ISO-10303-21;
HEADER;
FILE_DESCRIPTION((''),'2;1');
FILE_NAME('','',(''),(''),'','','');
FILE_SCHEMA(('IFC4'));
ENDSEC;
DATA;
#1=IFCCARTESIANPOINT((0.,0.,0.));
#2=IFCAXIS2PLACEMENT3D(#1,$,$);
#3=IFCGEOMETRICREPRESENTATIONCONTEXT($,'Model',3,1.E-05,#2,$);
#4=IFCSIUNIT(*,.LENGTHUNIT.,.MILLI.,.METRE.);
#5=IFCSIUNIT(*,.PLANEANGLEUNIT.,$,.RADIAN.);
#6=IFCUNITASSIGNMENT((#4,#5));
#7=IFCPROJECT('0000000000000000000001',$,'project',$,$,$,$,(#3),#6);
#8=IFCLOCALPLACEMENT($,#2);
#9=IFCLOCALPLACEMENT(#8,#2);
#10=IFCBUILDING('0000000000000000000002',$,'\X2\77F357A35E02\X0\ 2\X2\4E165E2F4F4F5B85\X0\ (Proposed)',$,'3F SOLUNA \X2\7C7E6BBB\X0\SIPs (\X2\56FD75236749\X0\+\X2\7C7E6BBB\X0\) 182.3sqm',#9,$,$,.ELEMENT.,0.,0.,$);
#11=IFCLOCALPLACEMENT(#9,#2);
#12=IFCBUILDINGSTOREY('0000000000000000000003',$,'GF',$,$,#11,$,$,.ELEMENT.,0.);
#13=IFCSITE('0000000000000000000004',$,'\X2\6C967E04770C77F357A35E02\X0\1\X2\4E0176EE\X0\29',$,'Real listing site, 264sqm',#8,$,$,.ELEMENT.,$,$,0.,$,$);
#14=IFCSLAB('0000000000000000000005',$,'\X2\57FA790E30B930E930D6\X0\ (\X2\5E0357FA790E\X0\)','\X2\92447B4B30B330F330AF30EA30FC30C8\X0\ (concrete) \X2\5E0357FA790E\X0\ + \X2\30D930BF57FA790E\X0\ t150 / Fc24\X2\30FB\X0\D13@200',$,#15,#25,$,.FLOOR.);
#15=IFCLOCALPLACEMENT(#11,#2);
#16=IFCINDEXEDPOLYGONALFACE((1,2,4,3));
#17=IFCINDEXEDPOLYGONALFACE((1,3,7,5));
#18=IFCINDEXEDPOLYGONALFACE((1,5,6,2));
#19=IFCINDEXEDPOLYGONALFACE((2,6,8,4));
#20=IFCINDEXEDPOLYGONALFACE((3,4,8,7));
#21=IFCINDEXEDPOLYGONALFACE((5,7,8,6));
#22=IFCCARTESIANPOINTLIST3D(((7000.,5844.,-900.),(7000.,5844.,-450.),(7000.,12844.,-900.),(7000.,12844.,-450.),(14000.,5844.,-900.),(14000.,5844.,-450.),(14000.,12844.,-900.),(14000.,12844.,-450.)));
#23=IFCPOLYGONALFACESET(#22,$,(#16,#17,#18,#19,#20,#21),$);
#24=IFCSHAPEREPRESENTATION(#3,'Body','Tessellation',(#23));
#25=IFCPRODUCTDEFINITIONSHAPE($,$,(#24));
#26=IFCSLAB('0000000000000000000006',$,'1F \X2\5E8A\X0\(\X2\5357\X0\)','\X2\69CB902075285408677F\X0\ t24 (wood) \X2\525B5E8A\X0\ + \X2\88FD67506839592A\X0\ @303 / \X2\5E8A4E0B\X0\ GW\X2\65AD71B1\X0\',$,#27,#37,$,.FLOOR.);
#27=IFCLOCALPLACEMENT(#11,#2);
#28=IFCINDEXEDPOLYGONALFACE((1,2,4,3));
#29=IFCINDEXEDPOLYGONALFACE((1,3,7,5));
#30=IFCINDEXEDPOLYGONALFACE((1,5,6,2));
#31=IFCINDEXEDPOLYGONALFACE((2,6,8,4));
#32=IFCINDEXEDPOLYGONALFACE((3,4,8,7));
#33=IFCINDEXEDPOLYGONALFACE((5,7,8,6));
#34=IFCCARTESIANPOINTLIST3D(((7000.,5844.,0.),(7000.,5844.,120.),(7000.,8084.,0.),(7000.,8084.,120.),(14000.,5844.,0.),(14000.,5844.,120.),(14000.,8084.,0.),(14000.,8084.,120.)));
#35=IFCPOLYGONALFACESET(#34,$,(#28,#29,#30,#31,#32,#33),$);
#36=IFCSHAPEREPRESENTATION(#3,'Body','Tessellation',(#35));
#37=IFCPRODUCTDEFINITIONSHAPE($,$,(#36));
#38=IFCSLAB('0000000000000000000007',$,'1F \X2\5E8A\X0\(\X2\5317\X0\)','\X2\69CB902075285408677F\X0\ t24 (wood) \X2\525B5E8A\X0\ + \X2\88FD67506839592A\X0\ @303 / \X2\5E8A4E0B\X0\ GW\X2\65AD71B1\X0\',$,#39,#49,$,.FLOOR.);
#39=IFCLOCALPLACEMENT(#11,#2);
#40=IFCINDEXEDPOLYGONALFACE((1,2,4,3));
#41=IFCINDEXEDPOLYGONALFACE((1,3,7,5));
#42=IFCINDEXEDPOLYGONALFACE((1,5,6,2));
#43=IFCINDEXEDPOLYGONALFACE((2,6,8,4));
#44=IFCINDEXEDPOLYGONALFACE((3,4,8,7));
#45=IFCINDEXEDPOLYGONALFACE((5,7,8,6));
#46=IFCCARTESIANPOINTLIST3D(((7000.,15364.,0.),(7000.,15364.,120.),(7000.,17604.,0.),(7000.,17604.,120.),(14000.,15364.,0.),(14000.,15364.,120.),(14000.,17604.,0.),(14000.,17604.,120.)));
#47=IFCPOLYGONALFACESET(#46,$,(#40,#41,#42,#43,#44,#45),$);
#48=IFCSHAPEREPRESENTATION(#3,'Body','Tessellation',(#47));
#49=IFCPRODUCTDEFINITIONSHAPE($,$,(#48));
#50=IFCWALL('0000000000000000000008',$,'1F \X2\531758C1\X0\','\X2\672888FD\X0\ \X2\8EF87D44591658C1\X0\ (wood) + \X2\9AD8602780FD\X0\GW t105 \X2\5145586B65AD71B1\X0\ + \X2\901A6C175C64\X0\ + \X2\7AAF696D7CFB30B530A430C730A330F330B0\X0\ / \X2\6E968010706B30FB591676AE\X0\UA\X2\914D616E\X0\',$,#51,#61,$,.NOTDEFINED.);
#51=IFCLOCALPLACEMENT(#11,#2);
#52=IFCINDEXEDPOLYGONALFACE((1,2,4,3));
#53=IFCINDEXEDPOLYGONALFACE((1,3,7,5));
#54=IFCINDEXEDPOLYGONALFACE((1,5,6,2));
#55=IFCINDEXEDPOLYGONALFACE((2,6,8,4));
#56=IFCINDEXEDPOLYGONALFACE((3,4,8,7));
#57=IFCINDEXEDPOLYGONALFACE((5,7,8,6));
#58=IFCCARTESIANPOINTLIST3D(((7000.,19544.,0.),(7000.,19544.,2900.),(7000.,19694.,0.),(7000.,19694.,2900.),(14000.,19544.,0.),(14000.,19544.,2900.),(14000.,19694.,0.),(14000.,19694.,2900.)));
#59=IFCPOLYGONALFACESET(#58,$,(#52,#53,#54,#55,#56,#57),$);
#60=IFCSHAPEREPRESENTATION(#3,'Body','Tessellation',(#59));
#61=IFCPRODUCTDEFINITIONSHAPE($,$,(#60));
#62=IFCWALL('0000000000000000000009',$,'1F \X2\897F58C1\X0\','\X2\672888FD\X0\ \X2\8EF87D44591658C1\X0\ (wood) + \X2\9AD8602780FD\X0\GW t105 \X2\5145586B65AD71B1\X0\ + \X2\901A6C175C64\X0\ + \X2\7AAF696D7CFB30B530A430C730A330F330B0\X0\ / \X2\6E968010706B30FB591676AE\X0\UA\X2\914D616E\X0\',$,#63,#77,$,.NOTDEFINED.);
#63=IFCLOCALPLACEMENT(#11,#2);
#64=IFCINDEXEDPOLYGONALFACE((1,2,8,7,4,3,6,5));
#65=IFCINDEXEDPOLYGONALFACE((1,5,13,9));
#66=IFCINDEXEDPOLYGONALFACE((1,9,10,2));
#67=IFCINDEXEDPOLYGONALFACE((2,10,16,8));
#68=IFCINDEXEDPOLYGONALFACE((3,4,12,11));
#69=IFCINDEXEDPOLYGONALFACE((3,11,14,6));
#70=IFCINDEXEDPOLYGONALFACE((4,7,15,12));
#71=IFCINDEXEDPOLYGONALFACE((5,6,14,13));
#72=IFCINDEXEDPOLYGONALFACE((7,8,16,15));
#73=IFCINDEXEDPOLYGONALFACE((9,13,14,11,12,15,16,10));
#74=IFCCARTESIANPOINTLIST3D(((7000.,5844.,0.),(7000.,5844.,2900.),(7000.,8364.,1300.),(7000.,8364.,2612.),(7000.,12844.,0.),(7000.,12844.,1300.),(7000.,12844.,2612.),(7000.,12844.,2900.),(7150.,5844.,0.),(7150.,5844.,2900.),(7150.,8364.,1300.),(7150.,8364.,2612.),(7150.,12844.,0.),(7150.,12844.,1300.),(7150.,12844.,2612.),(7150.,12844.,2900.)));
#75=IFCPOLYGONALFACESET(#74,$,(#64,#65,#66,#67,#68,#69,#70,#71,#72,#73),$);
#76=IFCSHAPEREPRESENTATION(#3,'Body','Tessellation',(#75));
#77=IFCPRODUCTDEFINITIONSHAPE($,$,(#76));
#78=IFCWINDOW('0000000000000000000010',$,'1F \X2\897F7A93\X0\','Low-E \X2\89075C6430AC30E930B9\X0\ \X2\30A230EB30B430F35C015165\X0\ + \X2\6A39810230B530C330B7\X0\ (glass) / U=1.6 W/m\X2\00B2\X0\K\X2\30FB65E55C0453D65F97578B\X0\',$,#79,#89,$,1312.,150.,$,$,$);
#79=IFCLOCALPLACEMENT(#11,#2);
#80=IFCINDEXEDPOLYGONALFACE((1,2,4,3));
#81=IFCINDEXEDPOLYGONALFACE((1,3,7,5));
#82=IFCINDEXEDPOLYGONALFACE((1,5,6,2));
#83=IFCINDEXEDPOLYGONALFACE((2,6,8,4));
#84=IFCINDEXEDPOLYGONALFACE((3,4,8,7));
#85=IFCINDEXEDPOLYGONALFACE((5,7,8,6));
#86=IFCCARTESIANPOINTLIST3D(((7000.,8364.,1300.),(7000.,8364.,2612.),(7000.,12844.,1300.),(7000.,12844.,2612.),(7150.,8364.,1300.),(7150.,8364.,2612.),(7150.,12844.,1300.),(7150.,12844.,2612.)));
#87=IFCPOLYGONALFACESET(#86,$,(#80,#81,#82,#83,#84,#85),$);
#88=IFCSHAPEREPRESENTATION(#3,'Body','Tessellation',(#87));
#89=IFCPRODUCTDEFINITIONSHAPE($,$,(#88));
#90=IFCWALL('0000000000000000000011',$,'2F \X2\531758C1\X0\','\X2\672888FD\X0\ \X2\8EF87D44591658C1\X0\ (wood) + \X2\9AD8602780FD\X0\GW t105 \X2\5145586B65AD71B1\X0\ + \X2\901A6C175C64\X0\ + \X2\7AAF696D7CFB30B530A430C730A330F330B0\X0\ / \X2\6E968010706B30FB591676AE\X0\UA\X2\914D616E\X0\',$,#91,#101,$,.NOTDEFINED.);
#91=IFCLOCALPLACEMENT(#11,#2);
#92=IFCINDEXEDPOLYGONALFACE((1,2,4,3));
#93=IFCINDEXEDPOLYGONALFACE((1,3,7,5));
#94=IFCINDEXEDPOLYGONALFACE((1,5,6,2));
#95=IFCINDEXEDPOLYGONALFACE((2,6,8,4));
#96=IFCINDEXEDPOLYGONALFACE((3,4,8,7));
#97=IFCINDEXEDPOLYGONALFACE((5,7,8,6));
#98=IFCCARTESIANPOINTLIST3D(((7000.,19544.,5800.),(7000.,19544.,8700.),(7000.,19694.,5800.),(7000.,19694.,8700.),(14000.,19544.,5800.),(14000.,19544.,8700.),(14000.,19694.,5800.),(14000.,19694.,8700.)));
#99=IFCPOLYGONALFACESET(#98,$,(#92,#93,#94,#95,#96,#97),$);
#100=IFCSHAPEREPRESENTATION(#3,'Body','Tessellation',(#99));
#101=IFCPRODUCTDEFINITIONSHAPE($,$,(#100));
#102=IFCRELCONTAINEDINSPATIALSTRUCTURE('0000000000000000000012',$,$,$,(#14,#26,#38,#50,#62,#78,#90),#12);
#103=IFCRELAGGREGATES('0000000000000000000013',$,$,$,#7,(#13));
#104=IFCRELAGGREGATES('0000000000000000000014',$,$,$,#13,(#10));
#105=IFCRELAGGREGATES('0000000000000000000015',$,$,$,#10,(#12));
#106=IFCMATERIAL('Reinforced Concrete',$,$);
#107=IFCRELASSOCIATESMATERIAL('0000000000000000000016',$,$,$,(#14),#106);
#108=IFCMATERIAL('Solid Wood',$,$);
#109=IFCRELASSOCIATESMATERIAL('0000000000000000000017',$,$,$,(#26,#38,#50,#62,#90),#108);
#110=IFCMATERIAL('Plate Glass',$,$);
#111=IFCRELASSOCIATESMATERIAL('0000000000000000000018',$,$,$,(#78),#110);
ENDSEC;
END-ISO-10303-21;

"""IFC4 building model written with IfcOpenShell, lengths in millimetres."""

from ifc_helpers import new_model, si_unit, frame, frame_2d, origin, place, context, project, spatial, rectangle, extrude, material, element, fill, save


model = new_model("IFC4")

# Units and contexts
model_context = context("Model", 3, precision=1e-05, world=origin())
ifc_project = project(units=[si_unit("LENGTHUNIT", "METRE", prefix="MILLI"), si_unit("PLANEANGLEUNIT", "RADIAN")], contexts=[model_context])

# Site, building, storey
site_placement = place(None, origin())
site = spatial("IfcSite", under=ifc_project, at=site_placement, Name="沖縄県石垣市1丁目29", ObjectType="Real listing site, 264sqm", CompositionType="ELEMENT", RefElevation=0.0)
building_placement = place(site_placement, origin())
building = spatial("IfcBuilding", under=site, at=building_placement, Name="石垣市 2世帯住宅 (Proposed)", ObjectType="3F SOLUNA 籾殻SIPs (国産杉+籾殻) 182.3sqm", CompositionType="ELEMENT", ElevationOfRefHeight=0.0, ElevationOfTerrain=0.0)
storey_placement = place(building_placement, origin())
storey = spatial("IfcBuildingStorey", under=building, at=storey_placement, Name="GF", CompositionType="ELEMENT", Elevation=0.0)

# Slabs
ifc_material_1 = material(Name="Reinforced Concrete")
slab_1_placement = place(storey_placement, frame((3500.0, 2922.0, -450.0)))
element("IfcSlab", 1, at=slab_1_placement, inside=storey, material=ifc_material_1, Name="基礎スラブ (布基礎)", Description="鉄筋コンクリート (concrete) 布基礎 + ベタ基礎 t150 / Fc24・D13@200", PredefinedType="FLOOR", context=model_context, shape_type="SweptSolid", body=[
    extrude(rectangle(XDim=7000.0, YDim=7000.0, at=frame_2d((3500.0, 3500.0))), frame((3500.0, 2922.0, -450.0)), (0.0, 0.0, 1.0), 450.0),
])
ifc_material_2 = material(Name="Solid Wood")
slab_2_placement = place(storey_placement, frame((3500.0, 2922.0, 0.0)))
element("IfcSlab", 2, at=slab_2_placement, inside=storey, material=ifc_material_2, Name="1F 床(南)", Description="構造用合板 t24 (wood) 剛床 + 製材根太 @303 / 床下 GW断熱", PredefinedType="FLOOR", context=model_context, shape_type="SweptSolid", body=[
    extrude(rectangle(XDim=7000.0, YDim=2240.0, at=frame_2d((3500.0, 1120.0))), frame((3500.0, 2922.0, 0.0)), (0.0, 0.0, 1.0), 120.0),
])
slab_3_placement = place(storey_placement, frame((3500.0, 7682.0, 0.0)))
element("IfcSlab", 3, at=slab_3_placement, inside=storey, material=ifc_material_2, Name="1F 床(北)", Description="構造用合板 t24 (wood) 剛床 + 製材根太 @303 / 床下 GW断熱", PredefinedType="FLOOR", context=model_context, shape_type="SweptSolid", body=[
    extrude(rectangle(XDim=7000.0, YDim=2240.0, at=frame_2d((3500.0, 1120.0))), frame((3500.0, 7682.0, 0.0)), (0.0, 0.0, 1.0), 120.0),
])

# Shared definitions
ifc_material_3 = material(Name="Plate Glass")

# Wall
wall_1_placement = place(storey_placement, frame((3500.0, 9772.0, 0.0)))
element("IfcWall", 4, at=wall_1_placement, inside=storey, material=ifc_material_2, Name="1F 北壁", Description="木製 軸組外壁 (wood) + 高性能GW t105 充填断熱 + 通気層 + 窯業系サイディング / 準耐火・外皮UA配慮", PredefinedType="NOTDEFINED", context=model_context, shape_type="SweptSolid", body=[
    extrude(rectangle(XDim=7000.0, YDim=150.0, at=frame_2d((3500.0, 75.0))), frame((3500.0, 9772.0, 0.0)), (0.0, 0.0, 1.0), 2900.0),
])

# Wall, opening, window
wall_2_placement = place(storey_placement, frame((3500.0, 2922.0, 0.0)))
wall_2 = element("IfcWall", 5, at=wall_2_placement, inside=storey, material=ifc_material_2, Name="1F 西壁", Description="木製 軸組外壁 (wood) + 高性能GW t105 充填断熱 + 通気層 + 窯業系サイディング / 準耐火・外皮UA配慮", PredefinedType="NOTDEFINED", context=model_context, shape_type="SweptSolid", body=[
    extrude(rectangle(XDim=150.0, YDim=7000.0, at=frame_2d((75.0, 3500.0))), frame((3500.0, 2922.0, 0.0)), (0.0, 0.0, 1.0), 2900.0),
])
opening_1_placement = place(storey_placement, frame((3500.0, 4182.0, 650.0)))
opening_1 = element("IfcOpeningElement", 6, at=opening_1_placement, cuts=wall_2, PredefinedType="NOTDEFINED", context=model_context, shape_type="SweptSolid", body=[
    extrude(rectangle(XDim=150.0, YDim=4480.0, at=frame_2d((75.0, 2240.0))), frame((3500.0, 4182.0, 650.0)), (0.0, 0.0, 1.0), 1312.0),
])
window_1_placement = place(storey_placement, frame((3500.0, 4182.0, 650.0)))
window_1 = element("IfcWindow", 7, at=window_1_placement, inside=storey, material=ifc_material_3, Name="1F 西窓", Description="Low-E 複層ガラス アルゴン封入 + 樹脂サッシ (glass) / U=1.6 W/m²K・日射取得型", OverallHeight=1312.0, OverallWidth=150.0, context=model_context, shape_type="SweptSolid", body=[
    extrude(rectangle(XDim=150.0, YDim=4480.0, at=frame_2d((75.0, 2240.0))), frame((3500.0, 4182.0, 650.0)), (0.0, 0.0, 1.0), 1312.0),
])
fill(opening_1, window_1)

# Wall
wall_3_placement = place(storey_placement, frame((3500.0, 9772.0, 2900.0)))
element("IfcWall", 8, at=wall_3_placement, inside=storey, material=ifc_material_2, Name="2F 北壁", Description="木製 軸組外壁 (wood) + 高性能GW t105 充填断熱 + 通気層 + 窯業系サイディング / 準耐火・外皮UA配慮", PredefinedType="NOTDEFINED", context=model_context, shape_type="SweptSolid", body=[
    extrude(rectangle(XDim=7000.0, YDim=150.0, at=frame_2d((3500.0, 75.0))), frame((3500.0, 9772.0, 2900.0)), (0.0, 0.0, 1.0), 2900.0),
])

save(model, "model.ifc")
